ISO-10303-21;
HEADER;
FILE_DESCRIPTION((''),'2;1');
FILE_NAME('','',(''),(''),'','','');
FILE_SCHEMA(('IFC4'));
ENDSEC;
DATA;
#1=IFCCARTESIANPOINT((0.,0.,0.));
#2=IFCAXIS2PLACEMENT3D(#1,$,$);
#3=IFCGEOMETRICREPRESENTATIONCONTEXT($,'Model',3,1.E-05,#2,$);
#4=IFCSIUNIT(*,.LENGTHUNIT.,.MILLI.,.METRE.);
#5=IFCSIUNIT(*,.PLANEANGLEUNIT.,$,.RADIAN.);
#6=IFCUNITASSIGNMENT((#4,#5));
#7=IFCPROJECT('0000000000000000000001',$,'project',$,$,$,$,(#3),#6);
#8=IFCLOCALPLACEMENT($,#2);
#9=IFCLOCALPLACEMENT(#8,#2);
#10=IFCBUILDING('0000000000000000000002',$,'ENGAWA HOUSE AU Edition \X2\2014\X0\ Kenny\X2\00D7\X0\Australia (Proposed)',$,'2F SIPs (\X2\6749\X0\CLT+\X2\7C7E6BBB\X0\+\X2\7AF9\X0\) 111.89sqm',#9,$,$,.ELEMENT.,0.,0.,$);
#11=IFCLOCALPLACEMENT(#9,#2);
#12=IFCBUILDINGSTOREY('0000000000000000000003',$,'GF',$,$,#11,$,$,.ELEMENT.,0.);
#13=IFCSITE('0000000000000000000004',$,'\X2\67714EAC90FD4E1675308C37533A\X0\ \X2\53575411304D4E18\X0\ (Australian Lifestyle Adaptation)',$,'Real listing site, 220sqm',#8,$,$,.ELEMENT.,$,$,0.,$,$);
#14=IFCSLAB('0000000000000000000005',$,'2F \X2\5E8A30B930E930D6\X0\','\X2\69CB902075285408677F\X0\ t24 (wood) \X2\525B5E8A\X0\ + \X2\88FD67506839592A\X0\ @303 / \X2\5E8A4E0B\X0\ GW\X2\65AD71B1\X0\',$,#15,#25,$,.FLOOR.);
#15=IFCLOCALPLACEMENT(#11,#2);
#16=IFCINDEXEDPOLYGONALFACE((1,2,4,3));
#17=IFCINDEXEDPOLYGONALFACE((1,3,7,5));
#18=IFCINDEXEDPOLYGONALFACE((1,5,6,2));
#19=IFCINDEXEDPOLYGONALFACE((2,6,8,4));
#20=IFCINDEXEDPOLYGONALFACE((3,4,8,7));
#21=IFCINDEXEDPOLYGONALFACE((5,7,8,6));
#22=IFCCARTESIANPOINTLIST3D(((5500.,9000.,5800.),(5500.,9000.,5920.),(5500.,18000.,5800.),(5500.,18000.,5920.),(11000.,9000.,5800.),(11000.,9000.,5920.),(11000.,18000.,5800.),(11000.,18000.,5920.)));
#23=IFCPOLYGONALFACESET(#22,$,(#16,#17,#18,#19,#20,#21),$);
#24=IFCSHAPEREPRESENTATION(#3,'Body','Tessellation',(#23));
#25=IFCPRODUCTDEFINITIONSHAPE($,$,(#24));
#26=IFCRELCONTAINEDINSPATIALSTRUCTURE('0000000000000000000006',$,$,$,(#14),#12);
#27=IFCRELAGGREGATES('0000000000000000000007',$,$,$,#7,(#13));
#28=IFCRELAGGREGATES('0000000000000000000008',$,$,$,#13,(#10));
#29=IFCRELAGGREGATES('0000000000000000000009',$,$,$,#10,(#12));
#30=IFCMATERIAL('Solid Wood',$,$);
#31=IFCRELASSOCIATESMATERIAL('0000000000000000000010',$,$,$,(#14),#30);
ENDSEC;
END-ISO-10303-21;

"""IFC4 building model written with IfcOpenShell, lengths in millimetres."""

from ifc_helpers import new_model, si_unit, frame, frame_2d, origin, place, context, project, spatial, rectangle, extrude, material, element, save


model = new_model("IFC4")

# Units and contexts
model_context = context("Model", 3, precision=1e-05, world=origin())
ifc_project = project(units=[si_unit("LENGTHUNIT", "METRE", prefix="MILLI"), si_unit("PLANEANGLEUNIT", "RADIAN")], contexts=[model_context])

# Site, building, storey
site_placement = place(None, origin())
site = spatial("IfcSite", under=ifc_project, at=site_placement, Name="東京都世田谷区 南向き丘 (Australian Lifestyle Adaptation)", ObjectType="Real listing site, 220sqm", CompositionType="ELEMENT", RefElevation=0.0)
building_placement = place(site_placement, origin())
building = spatial("IfcBuilding", under=site, at=building_placement, Name="ENGAWA HOUSE AU Edition — Kenny×Australia (Proposed)", ObjectType="2F SIPs (杉CLT+籾殻+竹) 111.89sqm", CompositionType="ELEMENT", ElevationOfRefHeight=0.0, ElevationOfTerrain=0.0)
storey_placement = place(building_placement, origin())
storey = spatial("IfcBuildingStorey", under=building, at=storey_placement, Name="GF", CompositionType="ELEMENT", Elevation=0.0)

# Slab
ifc_material_1 = material(Name="Solid Wood")
slab_placement = place(storey_placement, frame((2750.0, 4500.0, 2900.0)))
element("IfcSlab", 1, at=slab_placement, inside=storey, material=ifc_material_1, Name="2F 床スラブ", Description="構造用合板 t24 (wood) 剛床 + 製材根太 @303 / 床下 GW断熱", PredefinedType="FLOOR", context=model_context, shape_type="SweptSolid", body=[
    extrude(rectangle(XDim=5500.0, YDim=9000.0, at=frame_2d((2750.0, 4500.0))), frame((2750.0, 4500.0, 2900.0)), (0.0, 0.0, 1.0), 120.0),
])

save(model, "model.ifc")
